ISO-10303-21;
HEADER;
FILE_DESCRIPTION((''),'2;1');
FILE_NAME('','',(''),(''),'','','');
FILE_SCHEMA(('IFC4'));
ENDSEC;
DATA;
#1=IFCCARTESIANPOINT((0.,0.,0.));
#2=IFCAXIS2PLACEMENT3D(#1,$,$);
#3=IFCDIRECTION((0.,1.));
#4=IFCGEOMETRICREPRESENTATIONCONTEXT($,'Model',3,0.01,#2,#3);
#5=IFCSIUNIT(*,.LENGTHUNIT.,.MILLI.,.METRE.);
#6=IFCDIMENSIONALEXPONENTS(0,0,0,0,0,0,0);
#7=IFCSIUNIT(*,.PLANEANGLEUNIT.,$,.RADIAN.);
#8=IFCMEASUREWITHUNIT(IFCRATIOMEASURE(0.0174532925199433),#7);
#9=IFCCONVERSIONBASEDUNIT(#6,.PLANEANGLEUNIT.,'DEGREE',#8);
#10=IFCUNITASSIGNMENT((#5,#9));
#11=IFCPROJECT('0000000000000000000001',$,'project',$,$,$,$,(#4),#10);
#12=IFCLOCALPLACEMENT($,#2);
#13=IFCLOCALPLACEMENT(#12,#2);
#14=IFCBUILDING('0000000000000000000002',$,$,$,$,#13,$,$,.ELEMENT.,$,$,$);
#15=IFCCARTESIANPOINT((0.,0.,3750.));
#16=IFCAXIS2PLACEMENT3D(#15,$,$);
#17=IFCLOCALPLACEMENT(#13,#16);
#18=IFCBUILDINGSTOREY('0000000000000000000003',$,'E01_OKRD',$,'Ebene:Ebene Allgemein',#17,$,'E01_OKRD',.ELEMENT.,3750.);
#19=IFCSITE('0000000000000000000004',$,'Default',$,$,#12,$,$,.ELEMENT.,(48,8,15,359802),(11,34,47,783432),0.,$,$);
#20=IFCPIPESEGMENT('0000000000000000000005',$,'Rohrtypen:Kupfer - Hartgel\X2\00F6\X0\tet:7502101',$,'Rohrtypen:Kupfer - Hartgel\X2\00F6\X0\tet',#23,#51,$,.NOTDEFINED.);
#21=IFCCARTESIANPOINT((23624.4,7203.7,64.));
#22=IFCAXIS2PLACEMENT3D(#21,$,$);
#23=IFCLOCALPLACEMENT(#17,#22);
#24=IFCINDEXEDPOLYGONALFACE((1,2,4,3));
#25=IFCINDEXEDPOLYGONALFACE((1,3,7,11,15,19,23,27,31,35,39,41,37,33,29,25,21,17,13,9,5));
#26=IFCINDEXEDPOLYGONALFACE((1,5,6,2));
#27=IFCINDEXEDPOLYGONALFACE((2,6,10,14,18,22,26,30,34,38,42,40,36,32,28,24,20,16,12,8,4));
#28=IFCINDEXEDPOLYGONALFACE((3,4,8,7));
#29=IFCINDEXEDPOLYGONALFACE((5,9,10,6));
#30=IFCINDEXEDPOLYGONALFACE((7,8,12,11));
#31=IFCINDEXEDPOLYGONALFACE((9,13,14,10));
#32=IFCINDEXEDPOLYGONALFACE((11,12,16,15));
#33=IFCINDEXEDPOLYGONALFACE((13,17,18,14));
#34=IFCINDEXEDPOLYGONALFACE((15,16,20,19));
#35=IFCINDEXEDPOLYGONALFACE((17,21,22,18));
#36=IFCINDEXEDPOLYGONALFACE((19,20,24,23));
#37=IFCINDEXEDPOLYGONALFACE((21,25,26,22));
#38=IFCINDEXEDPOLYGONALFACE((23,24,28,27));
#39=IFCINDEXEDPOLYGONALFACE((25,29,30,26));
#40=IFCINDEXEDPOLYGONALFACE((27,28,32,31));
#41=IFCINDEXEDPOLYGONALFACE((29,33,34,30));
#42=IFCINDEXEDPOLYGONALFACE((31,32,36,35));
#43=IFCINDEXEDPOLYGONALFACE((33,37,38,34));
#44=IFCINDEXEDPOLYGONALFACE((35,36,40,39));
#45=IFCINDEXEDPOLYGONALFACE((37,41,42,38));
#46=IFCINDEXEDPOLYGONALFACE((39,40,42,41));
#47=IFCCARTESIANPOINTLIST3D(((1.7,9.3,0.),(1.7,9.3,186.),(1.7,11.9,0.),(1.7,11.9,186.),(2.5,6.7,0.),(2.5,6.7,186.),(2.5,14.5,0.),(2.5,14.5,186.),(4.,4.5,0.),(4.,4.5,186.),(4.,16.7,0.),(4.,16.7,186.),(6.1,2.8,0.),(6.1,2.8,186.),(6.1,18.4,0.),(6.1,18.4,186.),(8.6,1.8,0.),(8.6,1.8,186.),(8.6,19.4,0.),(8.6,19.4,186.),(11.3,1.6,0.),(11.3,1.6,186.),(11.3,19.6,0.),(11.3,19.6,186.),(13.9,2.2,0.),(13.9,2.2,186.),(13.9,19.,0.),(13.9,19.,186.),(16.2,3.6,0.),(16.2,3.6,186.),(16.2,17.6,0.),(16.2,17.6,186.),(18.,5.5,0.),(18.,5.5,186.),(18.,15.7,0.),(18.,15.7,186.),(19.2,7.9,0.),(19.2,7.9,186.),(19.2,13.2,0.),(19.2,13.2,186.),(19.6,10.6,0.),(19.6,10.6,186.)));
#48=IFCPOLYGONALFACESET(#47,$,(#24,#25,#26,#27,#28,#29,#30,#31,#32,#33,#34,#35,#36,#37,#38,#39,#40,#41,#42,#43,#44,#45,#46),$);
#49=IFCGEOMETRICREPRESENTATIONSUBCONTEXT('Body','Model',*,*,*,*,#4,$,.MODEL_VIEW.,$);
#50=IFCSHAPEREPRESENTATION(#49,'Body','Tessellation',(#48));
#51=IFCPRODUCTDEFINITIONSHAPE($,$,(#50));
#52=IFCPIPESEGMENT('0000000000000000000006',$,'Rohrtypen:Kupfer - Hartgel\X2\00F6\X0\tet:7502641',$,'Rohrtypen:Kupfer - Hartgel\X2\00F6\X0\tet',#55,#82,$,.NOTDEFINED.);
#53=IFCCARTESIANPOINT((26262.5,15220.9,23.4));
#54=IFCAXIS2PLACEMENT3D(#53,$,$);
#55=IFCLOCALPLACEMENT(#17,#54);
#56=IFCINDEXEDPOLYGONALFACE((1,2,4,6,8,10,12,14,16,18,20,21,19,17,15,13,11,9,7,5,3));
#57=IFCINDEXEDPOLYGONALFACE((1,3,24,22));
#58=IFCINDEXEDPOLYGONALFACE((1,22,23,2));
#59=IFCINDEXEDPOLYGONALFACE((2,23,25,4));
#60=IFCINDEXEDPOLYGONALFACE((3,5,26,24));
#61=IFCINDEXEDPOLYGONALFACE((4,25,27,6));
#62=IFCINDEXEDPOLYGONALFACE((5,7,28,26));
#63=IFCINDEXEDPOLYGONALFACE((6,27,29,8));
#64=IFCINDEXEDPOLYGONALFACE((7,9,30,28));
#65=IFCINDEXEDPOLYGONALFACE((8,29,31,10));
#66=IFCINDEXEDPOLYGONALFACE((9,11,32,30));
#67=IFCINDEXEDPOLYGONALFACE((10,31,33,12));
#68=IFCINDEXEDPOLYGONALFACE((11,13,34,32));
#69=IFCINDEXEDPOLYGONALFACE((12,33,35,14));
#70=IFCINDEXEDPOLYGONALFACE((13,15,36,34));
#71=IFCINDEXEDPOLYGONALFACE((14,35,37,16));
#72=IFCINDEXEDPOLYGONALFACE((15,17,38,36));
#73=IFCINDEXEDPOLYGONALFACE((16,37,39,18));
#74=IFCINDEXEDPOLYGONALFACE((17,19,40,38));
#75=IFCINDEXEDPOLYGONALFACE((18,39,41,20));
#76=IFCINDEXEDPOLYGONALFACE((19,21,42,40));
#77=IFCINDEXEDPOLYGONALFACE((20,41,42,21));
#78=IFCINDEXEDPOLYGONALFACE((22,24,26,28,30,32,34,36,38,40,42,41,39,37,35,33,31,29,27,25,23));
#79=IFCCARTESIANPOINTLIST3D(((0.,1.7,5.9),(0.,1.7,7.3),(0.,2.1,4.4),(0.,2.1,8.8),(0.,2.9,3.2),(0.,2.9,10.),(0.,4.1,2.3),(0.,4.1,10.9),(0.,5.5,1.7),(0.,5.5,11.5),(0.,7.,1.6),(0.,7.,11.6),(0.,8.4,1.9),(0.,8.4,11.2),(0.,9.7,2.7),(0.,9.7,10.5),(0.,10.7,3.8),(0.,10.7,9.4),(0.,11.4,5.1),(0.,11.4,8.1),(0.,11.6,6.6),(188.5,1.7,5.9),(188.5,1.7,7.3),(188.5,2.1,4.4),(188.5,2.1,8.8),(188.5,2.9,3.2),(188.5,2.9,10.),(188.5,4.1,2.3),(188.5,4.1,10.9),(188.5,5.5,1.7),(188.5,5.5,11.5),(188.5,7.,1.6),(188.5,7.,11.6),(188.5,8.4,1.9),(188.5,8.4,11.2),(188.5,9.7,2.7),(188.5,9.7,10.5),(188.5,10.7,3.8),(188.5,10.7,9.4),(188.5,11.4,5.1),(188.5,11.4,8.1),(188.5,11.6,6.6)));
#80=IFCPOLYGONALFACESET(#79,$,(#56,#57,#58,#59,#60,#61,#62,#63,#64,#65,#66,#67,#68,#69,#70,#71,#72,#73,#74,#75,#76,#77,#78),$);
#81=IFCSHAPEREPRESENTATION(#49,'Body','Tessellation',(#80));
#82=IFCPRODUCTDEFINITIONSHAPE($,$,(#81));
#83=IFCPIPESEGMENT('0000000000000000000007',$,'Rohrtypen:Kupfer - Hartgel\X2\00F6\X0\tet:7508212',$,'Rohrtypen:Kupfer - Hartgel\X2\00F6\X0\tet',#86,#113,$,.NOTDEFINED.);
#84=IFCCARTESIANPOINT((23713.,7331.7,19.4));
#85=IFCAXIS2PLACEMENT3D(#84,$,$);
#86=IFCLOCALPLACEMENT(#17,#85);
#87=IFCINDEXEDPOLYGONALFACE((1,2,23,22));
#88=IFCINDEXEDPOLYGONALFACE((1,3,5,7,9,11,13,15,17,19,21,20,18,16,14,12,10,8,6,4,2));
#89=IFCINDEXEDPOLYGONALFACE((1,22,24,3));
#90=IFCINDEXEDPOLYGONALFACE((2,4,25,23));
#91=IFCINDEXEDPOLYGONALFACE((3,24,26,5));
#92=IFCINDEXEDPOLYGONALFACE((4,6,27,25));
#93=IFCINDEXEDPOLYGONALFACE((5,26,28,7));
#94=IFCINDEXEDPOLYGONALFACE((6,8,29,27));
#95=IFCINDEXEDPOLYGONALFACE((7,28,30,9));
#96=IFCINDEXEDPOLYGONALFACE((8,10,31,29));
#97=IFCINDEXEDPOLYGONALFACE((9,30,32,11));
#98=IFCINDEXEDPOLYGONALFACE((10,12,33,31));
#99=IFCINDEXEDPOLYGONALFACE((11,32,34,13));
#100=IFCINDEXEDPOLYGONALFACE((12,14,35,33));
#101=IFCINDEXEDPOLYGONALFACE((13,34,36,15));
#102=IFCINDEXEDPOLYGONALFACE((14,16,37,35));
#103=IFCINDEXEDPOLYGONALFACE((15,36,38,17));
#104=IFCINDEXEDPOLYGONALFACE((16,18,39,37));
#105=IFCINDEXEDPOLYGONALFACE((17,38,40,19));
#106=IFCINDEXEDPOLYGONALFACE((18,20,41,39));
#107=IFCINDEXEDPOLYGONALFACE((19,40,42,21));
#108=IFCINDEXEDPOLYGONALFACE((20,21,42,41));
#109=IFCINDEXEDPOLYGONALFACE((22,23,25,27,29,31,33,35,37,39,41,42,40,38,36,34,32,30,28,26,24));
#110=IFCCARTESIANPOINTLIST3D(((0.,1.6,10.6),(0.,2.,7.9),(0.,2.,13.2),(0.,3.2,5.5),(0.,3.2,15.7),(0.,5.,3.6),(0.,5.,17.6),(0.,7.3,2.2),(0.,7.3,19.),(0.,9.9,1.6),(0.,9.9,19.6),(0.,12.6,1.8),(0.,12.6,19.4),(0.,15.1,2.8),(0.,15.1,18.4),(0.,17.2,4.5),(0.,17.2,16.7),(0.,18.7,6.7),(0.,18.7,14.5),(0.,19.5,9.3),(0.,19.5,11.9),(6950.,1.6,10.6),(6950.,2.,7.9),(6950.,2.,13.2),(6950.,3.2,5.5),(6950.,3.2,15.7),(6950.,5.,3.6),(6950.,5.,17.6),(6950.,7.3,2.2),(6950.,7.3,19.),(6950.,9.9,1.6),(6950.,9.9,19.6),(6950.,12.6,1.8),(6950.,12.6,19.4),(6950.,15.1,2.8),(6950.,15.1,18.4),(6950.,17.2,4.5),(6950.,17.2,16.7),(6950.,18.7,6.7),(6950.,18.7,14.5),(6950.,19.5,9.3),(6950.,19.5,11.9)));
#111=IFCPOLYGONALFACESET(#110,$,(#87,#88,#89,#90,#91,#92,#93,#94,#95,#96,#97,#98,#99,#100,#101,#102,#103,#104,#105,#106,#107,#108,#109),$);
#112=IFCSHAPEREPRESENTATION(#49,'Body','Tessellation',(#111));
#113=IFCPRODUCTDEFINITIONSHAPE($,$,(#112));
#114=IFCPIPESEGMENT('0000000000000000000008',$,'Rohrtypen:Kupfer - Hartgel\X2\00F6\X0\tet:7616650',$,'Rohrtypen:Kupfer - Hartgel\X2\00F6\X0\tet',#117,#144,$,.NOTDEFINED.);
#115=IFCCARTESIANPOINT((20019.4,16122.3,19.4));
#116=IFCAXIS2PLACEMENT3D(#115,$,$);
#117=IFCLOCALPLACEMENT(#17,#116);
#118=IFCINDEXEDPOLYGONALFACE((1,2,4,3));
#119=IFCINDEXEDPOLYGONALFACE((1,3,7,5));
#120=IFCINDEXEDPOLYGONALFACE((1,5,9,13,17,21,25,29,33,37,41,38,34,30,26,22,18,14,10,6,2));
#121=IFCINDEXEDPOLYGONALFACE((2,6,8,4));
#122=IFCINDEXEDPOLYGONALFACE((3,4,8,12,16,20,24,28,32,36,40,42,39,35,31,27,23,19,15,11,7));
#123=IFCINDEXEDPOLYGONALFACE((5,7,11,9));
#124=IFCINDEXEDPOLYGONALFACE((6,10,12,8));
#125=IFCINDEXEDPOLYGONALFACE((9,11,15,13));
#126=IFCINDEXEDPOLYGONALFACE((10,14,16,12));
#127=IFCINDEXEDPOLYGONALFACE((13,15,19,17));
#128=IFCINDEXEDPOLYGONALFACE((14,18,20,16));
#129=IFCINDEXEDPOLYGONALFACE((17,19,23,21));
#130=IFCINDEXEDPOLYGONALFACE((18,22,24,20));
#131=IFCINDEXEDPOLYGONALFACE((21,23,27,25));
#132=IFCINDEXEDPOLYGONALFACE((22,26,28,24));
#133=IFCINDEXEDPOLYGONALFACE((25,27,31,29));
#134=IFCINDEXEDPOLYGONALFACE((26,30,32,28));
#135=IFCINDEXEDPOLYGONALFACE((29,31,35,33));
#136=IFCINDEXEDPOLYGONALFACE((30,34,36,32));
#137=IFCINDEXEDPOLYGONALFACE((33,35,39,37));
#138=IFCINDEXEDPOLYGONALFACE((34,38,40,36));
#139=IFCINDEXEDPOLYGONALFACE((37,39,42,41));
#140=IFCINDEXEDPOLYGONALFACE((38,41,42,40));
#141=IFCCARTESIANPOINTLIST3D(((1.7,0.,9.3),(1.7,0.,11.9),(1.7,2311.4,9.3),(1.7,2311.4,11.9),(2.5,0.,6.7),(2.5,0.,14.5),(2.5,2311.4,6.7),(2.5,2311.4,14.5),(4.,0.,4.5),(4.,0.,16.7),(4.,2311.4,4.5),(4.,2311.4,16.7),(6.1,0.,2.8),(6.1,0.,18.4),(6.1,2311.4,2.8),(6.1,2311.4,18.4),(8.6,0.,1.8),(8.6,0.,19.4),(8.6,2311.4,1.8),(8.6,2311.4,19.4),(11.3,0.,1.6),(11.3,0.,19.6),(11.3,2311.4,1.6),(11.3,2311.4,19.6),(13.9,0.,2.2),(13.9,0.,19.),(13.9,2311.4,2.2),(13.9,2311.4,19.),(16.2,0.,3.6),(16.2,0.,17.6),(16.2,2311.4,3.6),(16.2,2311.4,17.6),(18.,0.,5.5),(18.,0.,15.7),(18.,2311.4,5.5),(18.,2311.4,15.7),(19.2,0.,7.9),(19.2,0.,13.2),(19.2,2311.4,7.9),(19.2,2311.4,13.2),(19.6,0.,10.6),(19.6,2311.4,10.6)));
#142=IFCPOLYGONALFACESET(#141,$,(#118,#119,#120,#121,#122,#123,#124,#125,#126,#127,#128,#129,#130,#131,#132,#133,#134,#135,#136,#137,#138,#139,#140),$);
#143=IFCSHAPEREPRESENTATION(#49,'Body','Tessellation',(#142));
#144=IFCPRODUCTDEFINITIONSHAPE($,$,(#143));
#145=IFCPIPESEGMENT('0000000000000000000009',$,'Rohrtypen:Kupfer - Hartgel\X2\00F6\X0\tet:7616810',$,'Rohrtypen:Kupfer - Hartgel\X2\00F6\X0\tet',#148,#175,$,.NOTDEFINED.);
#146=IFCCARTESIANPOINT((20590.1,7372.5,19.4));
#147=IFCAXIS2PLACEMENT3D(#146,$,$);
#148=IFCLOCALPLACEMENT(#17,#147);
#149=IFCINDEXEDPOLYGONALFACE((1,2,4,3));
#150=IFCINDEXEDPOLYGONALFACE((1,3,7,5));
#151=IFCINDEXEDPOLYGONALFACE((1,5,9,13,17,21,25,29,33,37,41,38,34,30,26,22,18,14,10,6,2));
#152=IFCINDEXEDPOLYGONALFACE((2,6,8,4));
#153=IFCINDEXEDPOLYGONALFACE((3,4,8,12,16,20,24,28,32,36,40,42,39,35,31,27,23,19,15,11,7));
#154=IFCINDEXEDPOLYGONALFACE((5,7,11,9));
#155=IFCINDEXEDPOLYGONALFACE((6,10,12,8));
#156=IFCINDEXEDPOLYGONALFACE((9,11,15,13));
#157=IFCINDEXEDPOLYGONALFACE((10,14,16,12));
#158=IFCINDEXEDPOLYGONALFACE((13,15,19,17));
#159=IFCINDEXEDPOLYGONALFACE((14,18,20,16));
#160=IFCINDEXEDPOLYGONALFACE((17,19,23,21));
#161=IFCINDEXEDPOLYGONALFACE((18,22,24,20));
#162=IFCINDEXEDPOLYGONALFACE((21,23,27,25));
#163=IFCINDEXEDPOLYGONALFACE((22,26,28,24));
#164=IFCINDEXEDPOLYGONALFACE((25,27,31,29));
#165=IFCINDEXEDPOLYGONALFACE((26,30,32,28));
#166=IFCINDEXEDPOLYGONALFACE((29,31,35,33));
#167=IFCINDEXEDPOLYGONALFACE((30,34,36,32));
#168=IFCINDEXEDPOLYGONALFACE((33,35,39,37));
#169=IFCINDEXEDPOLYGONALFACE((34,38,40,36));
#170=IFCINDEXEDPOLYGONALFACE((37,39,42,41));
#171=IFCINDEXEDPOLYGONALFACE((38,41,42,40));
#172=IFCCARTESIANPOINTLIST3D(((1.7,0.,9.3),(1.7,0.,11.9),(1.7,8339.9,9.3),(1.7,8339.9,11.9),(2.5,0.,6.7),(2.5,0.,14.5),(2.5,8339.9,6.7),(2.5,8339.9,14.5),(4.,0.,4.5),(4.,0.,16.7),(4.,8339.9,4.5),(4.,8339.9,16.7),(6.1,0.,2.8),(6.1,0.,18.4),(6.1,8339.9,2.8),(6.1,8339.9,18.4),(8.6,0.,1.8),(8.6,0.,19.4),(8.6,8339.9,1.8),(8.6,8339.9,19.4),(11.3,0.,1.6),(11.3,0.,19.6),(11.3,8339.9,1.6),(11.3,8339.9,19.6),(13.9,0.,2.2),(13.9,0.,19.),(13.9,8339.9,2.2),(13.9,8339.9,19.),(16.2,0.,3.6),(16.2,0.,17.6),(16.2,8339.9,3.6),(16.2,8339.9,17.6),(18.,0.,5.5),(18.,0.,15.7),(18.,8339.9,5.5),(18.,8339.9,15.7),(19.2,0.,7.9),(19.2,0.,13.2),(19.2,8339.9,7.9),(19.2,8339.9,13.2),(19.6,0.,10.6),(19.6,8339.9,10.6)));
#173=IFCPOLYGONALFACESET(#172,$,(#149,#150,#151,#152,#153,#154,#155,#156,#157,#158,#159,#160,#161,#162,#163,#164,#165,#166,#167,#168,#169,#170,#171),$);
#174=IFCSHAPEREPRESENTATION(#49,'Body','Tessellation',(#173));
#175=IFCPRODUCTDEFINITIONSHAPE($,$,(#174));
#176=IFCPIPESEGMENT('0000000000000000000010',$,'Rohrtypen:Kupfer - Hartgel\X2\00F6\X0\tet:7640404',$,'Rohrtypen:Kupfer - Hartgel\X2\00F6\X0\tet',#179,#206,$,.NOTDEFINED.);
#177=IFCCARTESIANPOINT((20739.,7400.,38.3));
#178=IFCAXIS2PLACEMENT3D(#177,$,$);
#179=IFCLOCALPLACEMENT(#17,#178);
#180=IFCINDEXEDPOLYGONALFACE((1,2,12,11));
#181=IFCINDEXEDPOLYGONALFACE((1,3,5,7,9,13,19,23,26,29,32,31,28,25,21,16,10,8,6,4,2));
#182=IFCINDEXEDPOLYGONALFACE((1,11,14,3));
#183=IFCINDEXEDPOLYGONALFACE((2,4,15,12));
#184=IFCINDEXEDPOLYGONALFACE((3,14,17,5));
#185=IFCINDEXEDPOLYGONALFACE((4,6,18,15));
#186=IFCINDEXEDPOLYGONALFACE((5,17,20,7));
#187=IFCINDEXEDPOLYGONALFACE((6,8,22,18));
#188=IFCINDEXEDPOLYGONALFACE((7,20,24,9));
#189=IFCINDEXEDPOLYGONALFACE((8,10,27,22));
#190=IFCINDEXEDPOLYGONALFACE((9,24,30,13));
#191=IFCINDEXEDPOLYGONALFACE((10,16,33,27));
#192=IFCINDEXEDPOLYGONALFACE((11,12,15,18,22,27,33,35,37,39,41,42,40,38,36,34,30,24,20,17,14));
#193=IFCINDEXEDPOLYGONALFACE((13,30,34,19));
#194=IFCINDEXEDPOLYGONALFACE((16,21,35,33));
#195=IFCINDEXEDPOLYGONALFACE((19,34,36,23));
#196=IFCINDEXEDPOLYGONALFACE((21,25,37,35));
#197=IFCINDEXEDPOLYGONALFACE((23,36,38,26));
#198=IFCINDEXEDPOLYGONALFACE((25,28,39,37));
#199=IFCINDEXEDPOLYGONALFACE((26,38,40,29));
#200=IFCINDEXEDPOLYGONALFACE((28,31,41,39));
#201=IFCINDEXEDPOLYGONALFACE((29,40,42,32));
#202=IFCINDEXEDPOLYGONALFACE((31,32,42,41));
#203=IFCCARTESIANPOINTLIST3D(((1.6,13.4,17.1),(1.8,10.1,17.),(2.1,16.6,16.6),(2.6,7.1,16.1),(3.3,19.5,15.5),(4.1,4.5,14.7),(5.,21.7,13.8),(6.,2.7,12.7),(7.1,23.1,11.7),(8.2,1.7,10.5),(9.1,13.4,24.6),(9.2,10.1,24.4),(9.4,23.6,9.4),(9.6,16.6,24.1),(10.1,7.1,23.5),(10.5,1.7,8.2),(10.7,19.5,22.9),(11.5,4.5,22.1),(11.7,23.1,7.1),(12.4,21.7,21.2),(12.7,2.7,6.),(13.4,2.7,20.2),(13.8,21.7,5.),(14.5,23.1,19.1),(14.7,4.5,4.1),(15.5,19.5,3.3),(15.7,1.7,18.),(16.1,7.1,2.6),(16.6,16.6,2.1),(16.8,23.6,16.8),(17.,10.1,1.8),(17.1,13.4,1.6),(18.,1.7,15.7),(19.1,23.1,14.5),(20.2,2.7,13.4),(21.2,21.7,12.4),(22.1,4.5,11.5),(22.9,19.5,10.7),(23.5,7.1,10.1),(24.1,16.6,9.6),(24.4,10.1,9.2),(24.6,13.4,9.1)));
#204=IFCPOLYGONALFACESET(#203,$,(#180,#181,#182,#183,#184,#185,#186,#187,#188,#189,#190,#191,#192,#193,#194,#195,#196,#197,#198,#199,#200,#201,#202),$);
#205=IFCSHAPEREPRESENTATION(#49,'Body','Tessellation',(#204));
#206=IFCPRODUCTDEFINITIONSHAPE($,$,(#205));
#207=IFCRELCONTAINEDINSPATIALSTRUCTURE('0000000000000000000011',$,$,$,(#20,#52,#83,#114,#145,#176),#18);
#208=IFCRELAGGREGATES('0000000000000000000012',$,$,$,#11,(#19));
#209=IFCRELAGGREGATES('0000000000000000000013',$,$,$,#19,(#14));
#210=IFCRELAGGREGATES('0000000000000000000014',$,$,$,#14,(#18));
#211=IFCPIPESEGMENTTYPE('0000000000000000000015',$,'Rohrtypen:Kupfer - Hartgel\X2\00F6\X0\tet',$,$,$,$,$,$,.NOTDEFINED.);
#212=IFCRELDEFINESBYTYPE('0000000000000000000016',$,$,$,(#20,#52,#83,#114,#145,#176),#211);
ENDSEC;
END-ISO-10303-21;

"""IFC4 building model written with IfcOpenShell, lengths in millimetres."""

from ifc_helpers import new_model, entity, si_unit, converted_unit, direction, frame, frame_2d, origin, origin_2d_with_axis, place, context, subcontext, project, spatial, circle, extrude, type_object, element, save


model = new_model("IFC4")

# Units and contexts
model_context = context("Model", 3, precision=0.01, world=origin(), true_north=direction((0.0, 1.0)))
body_context = subcontext(model_context, "Body", "Model", "MODEL_VIEW")
ifc_project = project(units=[si_unit("LENGTHUNIT", "METRE", prefix="MILLI"), converted_unit("PLANEANGLEUNIT", "DEGREE", entity("IfcRatioMeasure", 0.0174532925199433), si_unit("PLANEANGLEUNIT", "RADIAN"), dimensions=[0, 0, 0, 0, 0, 0, 0])], contexts=[model_context])

# Site, building, storey
site_placement = place(None, origin())
site = spatial("IfcSite", under=ifc_project, at=site_placement, Name="Default", CompositionType="ELEMENT", RefLatitude=(48, 8, 15, 359802), RefLongitude=(11, 34, 47, 783432), RefElevation=0.0)
building_placement = place(site_placement, origin())
building = spatial("IfcBuilding", under=site, at=building_placement, CompositionType="ELEMENT")
storey_placement = place(building_placement, frame((0.0, 0.0, 3750.0)))
storey = spatial("IfcBuildingStorey", under=building, at=storey_placement, Name="E01_OKRD", ObjectType="Ebene:Ebene Allgemein", LongName="E01_OKRD", CompositionType="ELEMENT", Elevation=3750.0)

# Pipe segments
pipe_segment_type = type_object("IfcPipeSegmentType", Name="Rohrtypen:Kupfer - Hartgelötet", PredefinedType="NOTDEFINED")
pipe_segment_1_placement = place(storey_placement, frame((23624.4, 7203.7, 64.0)))
element("IfcPipeSegment", 1, at=pipe_segment_1_placement, inside=storey, type_object=pipe_segment_type, Name="Rohrtypen:Kupfer - Hartgelötet:7502101", ObjectType="Rohrtypen:Kupfer - Hartgelötet", PredefinedType="NOTDEFINED", context=body_context, shape_type="SweptSolid", body=[
    extrude(circle(Radius=9.0, at=origin_2d_with_axis()), frame((10.6, 10.6, 0.0)), (0.0, 0.0, 1.0), 186.0),
])
pipe_segment_2_placement = place(storey_placement, frame((26262.5, 15220.9, 23.4)))
element("IfcPipeSegment", 2, at=pipe_segment_2_placement, inside=storey, type_object=pipe_segment_type, Name="Rohrtypen:Kupfer - Hartgelötet:7502641", ObjectType="Rohrtypen:Kupfer - Hartgelötet", PredefinedType="NOTDEFINED", context=body_context, shape_type="SweptSolid", body=[
    extrude(circle(Radius=5.0, at=frame_2d((0.0, 0.0), x_axis=(1.0, 0.0))), frame((0.0, 6.6, 6.6), z_axis=(1.0, 0.0, 0.0), x_axis=(0.0, 1.0, 0.0)), (0.0, 0.0, 1.0), 188.5),
])
pipe_segment_3_placement = place(storey_placement, frame((23713.0, 7331.7, 19.4)))
element("IfcPipeSegment", 3, at=pipe_segment_3_placement, inside=storey, type_object=pipe_segment_type, Name="Rohrtypen:Kupfer - Hartgelötet:7508212", ObjectType="Rohrtypen:Kupfer - Hartgelötet", PredefinedType="NOTDEFINED", context=body_context, shape_type="SweptSolid", body=[
    extrude(circle(Radius=9.0, at=origin_2d_with_axis()), frame((0.0, 10.6, 10.6), z_axis=(1.0, 0.0, 0.0), x_axis=(0.0, -1.0, 0.0)), (0.0, 0.0, 1.0), 6950.0),
])
pipe_segment_4_placement = place(storey_placement, frame((20019.4, 16122.3, 19.4)))
element("IfcPipeSegment", 4, at=pipe_segment_4_placement, inside=storey, type_object=pipe_segment_type, Name="Rohrtypen:Kupfer - Hartgelötet:7616650", ObjectType="Rohrtypen:Kupfer - Hartgelötet", PredefinedType="NOTDEFINED", context=body_context, shape_type="SweptSolid", body=[
    extrude(circle(Radius=9.0, at=origin_2d_with_axis()), frame((10.6, 0.0, 10.6), z_axis=(0.0, 1.0, 0.0), x_axis=(1.0, 0.0, 0.0)), (0.0, 0.0, 1.0), 2311.4),
])
pipe_segment_5_placement = place(storey_placement, frame((20590.1, 7372.5, 19.4)))
element("IfcPipeSegment", 5, at=pipe_segment_5_placement, inside=storey, type_object=pipe_segment_type, Name="Rohrtypen:Kupfer - Hartgelötet:7616810", ObjectType="Rohrtypen:Kupfer - Hartgelötet", PredefinedType="NOTDEFINED", context=body_context, shape_type="SweptSolid", body=[
    extrude(circle(Radius=9.0, at=origin_2d_with_axis()), frame((10.6, 0.0, 10.6), z_axis=(0.0, 1.0, 0.0), x_axis=(1.0, 0.0, 0.0)), (0.0, 0.0, 1.0), 8339.9),
])
pipe_segment_6_placement = place(storey_placement, frame((20739.0, 7400.0, 38.3)))
element("IfcPipeSegment", 6, at=pipe_segment_6_placement, inside=storey, type_object=pipe_segment_type, Name="Rohrtypen:Kupfer - Hartgelötet:7640404", ObjectType="Rohrtypen:Kupfer - Hartgelötet", PredefinedType="NOTDEFINED", context=body_context, shape_type="SweptSolid", body=[
    extrude(circle(Radius=11.0, at=frame_2d((0.0, 0.0), x_axis=(1.0, 0.0))), frame((9.4, 12.6, 9.4), z_axis=(0.707107, 0.0, 0.707107), x_axis=(0.0, 1.0, 0.0)), (0.0, 0.0, 1.0), 10.5),
])

save(model, "model.ifc")
